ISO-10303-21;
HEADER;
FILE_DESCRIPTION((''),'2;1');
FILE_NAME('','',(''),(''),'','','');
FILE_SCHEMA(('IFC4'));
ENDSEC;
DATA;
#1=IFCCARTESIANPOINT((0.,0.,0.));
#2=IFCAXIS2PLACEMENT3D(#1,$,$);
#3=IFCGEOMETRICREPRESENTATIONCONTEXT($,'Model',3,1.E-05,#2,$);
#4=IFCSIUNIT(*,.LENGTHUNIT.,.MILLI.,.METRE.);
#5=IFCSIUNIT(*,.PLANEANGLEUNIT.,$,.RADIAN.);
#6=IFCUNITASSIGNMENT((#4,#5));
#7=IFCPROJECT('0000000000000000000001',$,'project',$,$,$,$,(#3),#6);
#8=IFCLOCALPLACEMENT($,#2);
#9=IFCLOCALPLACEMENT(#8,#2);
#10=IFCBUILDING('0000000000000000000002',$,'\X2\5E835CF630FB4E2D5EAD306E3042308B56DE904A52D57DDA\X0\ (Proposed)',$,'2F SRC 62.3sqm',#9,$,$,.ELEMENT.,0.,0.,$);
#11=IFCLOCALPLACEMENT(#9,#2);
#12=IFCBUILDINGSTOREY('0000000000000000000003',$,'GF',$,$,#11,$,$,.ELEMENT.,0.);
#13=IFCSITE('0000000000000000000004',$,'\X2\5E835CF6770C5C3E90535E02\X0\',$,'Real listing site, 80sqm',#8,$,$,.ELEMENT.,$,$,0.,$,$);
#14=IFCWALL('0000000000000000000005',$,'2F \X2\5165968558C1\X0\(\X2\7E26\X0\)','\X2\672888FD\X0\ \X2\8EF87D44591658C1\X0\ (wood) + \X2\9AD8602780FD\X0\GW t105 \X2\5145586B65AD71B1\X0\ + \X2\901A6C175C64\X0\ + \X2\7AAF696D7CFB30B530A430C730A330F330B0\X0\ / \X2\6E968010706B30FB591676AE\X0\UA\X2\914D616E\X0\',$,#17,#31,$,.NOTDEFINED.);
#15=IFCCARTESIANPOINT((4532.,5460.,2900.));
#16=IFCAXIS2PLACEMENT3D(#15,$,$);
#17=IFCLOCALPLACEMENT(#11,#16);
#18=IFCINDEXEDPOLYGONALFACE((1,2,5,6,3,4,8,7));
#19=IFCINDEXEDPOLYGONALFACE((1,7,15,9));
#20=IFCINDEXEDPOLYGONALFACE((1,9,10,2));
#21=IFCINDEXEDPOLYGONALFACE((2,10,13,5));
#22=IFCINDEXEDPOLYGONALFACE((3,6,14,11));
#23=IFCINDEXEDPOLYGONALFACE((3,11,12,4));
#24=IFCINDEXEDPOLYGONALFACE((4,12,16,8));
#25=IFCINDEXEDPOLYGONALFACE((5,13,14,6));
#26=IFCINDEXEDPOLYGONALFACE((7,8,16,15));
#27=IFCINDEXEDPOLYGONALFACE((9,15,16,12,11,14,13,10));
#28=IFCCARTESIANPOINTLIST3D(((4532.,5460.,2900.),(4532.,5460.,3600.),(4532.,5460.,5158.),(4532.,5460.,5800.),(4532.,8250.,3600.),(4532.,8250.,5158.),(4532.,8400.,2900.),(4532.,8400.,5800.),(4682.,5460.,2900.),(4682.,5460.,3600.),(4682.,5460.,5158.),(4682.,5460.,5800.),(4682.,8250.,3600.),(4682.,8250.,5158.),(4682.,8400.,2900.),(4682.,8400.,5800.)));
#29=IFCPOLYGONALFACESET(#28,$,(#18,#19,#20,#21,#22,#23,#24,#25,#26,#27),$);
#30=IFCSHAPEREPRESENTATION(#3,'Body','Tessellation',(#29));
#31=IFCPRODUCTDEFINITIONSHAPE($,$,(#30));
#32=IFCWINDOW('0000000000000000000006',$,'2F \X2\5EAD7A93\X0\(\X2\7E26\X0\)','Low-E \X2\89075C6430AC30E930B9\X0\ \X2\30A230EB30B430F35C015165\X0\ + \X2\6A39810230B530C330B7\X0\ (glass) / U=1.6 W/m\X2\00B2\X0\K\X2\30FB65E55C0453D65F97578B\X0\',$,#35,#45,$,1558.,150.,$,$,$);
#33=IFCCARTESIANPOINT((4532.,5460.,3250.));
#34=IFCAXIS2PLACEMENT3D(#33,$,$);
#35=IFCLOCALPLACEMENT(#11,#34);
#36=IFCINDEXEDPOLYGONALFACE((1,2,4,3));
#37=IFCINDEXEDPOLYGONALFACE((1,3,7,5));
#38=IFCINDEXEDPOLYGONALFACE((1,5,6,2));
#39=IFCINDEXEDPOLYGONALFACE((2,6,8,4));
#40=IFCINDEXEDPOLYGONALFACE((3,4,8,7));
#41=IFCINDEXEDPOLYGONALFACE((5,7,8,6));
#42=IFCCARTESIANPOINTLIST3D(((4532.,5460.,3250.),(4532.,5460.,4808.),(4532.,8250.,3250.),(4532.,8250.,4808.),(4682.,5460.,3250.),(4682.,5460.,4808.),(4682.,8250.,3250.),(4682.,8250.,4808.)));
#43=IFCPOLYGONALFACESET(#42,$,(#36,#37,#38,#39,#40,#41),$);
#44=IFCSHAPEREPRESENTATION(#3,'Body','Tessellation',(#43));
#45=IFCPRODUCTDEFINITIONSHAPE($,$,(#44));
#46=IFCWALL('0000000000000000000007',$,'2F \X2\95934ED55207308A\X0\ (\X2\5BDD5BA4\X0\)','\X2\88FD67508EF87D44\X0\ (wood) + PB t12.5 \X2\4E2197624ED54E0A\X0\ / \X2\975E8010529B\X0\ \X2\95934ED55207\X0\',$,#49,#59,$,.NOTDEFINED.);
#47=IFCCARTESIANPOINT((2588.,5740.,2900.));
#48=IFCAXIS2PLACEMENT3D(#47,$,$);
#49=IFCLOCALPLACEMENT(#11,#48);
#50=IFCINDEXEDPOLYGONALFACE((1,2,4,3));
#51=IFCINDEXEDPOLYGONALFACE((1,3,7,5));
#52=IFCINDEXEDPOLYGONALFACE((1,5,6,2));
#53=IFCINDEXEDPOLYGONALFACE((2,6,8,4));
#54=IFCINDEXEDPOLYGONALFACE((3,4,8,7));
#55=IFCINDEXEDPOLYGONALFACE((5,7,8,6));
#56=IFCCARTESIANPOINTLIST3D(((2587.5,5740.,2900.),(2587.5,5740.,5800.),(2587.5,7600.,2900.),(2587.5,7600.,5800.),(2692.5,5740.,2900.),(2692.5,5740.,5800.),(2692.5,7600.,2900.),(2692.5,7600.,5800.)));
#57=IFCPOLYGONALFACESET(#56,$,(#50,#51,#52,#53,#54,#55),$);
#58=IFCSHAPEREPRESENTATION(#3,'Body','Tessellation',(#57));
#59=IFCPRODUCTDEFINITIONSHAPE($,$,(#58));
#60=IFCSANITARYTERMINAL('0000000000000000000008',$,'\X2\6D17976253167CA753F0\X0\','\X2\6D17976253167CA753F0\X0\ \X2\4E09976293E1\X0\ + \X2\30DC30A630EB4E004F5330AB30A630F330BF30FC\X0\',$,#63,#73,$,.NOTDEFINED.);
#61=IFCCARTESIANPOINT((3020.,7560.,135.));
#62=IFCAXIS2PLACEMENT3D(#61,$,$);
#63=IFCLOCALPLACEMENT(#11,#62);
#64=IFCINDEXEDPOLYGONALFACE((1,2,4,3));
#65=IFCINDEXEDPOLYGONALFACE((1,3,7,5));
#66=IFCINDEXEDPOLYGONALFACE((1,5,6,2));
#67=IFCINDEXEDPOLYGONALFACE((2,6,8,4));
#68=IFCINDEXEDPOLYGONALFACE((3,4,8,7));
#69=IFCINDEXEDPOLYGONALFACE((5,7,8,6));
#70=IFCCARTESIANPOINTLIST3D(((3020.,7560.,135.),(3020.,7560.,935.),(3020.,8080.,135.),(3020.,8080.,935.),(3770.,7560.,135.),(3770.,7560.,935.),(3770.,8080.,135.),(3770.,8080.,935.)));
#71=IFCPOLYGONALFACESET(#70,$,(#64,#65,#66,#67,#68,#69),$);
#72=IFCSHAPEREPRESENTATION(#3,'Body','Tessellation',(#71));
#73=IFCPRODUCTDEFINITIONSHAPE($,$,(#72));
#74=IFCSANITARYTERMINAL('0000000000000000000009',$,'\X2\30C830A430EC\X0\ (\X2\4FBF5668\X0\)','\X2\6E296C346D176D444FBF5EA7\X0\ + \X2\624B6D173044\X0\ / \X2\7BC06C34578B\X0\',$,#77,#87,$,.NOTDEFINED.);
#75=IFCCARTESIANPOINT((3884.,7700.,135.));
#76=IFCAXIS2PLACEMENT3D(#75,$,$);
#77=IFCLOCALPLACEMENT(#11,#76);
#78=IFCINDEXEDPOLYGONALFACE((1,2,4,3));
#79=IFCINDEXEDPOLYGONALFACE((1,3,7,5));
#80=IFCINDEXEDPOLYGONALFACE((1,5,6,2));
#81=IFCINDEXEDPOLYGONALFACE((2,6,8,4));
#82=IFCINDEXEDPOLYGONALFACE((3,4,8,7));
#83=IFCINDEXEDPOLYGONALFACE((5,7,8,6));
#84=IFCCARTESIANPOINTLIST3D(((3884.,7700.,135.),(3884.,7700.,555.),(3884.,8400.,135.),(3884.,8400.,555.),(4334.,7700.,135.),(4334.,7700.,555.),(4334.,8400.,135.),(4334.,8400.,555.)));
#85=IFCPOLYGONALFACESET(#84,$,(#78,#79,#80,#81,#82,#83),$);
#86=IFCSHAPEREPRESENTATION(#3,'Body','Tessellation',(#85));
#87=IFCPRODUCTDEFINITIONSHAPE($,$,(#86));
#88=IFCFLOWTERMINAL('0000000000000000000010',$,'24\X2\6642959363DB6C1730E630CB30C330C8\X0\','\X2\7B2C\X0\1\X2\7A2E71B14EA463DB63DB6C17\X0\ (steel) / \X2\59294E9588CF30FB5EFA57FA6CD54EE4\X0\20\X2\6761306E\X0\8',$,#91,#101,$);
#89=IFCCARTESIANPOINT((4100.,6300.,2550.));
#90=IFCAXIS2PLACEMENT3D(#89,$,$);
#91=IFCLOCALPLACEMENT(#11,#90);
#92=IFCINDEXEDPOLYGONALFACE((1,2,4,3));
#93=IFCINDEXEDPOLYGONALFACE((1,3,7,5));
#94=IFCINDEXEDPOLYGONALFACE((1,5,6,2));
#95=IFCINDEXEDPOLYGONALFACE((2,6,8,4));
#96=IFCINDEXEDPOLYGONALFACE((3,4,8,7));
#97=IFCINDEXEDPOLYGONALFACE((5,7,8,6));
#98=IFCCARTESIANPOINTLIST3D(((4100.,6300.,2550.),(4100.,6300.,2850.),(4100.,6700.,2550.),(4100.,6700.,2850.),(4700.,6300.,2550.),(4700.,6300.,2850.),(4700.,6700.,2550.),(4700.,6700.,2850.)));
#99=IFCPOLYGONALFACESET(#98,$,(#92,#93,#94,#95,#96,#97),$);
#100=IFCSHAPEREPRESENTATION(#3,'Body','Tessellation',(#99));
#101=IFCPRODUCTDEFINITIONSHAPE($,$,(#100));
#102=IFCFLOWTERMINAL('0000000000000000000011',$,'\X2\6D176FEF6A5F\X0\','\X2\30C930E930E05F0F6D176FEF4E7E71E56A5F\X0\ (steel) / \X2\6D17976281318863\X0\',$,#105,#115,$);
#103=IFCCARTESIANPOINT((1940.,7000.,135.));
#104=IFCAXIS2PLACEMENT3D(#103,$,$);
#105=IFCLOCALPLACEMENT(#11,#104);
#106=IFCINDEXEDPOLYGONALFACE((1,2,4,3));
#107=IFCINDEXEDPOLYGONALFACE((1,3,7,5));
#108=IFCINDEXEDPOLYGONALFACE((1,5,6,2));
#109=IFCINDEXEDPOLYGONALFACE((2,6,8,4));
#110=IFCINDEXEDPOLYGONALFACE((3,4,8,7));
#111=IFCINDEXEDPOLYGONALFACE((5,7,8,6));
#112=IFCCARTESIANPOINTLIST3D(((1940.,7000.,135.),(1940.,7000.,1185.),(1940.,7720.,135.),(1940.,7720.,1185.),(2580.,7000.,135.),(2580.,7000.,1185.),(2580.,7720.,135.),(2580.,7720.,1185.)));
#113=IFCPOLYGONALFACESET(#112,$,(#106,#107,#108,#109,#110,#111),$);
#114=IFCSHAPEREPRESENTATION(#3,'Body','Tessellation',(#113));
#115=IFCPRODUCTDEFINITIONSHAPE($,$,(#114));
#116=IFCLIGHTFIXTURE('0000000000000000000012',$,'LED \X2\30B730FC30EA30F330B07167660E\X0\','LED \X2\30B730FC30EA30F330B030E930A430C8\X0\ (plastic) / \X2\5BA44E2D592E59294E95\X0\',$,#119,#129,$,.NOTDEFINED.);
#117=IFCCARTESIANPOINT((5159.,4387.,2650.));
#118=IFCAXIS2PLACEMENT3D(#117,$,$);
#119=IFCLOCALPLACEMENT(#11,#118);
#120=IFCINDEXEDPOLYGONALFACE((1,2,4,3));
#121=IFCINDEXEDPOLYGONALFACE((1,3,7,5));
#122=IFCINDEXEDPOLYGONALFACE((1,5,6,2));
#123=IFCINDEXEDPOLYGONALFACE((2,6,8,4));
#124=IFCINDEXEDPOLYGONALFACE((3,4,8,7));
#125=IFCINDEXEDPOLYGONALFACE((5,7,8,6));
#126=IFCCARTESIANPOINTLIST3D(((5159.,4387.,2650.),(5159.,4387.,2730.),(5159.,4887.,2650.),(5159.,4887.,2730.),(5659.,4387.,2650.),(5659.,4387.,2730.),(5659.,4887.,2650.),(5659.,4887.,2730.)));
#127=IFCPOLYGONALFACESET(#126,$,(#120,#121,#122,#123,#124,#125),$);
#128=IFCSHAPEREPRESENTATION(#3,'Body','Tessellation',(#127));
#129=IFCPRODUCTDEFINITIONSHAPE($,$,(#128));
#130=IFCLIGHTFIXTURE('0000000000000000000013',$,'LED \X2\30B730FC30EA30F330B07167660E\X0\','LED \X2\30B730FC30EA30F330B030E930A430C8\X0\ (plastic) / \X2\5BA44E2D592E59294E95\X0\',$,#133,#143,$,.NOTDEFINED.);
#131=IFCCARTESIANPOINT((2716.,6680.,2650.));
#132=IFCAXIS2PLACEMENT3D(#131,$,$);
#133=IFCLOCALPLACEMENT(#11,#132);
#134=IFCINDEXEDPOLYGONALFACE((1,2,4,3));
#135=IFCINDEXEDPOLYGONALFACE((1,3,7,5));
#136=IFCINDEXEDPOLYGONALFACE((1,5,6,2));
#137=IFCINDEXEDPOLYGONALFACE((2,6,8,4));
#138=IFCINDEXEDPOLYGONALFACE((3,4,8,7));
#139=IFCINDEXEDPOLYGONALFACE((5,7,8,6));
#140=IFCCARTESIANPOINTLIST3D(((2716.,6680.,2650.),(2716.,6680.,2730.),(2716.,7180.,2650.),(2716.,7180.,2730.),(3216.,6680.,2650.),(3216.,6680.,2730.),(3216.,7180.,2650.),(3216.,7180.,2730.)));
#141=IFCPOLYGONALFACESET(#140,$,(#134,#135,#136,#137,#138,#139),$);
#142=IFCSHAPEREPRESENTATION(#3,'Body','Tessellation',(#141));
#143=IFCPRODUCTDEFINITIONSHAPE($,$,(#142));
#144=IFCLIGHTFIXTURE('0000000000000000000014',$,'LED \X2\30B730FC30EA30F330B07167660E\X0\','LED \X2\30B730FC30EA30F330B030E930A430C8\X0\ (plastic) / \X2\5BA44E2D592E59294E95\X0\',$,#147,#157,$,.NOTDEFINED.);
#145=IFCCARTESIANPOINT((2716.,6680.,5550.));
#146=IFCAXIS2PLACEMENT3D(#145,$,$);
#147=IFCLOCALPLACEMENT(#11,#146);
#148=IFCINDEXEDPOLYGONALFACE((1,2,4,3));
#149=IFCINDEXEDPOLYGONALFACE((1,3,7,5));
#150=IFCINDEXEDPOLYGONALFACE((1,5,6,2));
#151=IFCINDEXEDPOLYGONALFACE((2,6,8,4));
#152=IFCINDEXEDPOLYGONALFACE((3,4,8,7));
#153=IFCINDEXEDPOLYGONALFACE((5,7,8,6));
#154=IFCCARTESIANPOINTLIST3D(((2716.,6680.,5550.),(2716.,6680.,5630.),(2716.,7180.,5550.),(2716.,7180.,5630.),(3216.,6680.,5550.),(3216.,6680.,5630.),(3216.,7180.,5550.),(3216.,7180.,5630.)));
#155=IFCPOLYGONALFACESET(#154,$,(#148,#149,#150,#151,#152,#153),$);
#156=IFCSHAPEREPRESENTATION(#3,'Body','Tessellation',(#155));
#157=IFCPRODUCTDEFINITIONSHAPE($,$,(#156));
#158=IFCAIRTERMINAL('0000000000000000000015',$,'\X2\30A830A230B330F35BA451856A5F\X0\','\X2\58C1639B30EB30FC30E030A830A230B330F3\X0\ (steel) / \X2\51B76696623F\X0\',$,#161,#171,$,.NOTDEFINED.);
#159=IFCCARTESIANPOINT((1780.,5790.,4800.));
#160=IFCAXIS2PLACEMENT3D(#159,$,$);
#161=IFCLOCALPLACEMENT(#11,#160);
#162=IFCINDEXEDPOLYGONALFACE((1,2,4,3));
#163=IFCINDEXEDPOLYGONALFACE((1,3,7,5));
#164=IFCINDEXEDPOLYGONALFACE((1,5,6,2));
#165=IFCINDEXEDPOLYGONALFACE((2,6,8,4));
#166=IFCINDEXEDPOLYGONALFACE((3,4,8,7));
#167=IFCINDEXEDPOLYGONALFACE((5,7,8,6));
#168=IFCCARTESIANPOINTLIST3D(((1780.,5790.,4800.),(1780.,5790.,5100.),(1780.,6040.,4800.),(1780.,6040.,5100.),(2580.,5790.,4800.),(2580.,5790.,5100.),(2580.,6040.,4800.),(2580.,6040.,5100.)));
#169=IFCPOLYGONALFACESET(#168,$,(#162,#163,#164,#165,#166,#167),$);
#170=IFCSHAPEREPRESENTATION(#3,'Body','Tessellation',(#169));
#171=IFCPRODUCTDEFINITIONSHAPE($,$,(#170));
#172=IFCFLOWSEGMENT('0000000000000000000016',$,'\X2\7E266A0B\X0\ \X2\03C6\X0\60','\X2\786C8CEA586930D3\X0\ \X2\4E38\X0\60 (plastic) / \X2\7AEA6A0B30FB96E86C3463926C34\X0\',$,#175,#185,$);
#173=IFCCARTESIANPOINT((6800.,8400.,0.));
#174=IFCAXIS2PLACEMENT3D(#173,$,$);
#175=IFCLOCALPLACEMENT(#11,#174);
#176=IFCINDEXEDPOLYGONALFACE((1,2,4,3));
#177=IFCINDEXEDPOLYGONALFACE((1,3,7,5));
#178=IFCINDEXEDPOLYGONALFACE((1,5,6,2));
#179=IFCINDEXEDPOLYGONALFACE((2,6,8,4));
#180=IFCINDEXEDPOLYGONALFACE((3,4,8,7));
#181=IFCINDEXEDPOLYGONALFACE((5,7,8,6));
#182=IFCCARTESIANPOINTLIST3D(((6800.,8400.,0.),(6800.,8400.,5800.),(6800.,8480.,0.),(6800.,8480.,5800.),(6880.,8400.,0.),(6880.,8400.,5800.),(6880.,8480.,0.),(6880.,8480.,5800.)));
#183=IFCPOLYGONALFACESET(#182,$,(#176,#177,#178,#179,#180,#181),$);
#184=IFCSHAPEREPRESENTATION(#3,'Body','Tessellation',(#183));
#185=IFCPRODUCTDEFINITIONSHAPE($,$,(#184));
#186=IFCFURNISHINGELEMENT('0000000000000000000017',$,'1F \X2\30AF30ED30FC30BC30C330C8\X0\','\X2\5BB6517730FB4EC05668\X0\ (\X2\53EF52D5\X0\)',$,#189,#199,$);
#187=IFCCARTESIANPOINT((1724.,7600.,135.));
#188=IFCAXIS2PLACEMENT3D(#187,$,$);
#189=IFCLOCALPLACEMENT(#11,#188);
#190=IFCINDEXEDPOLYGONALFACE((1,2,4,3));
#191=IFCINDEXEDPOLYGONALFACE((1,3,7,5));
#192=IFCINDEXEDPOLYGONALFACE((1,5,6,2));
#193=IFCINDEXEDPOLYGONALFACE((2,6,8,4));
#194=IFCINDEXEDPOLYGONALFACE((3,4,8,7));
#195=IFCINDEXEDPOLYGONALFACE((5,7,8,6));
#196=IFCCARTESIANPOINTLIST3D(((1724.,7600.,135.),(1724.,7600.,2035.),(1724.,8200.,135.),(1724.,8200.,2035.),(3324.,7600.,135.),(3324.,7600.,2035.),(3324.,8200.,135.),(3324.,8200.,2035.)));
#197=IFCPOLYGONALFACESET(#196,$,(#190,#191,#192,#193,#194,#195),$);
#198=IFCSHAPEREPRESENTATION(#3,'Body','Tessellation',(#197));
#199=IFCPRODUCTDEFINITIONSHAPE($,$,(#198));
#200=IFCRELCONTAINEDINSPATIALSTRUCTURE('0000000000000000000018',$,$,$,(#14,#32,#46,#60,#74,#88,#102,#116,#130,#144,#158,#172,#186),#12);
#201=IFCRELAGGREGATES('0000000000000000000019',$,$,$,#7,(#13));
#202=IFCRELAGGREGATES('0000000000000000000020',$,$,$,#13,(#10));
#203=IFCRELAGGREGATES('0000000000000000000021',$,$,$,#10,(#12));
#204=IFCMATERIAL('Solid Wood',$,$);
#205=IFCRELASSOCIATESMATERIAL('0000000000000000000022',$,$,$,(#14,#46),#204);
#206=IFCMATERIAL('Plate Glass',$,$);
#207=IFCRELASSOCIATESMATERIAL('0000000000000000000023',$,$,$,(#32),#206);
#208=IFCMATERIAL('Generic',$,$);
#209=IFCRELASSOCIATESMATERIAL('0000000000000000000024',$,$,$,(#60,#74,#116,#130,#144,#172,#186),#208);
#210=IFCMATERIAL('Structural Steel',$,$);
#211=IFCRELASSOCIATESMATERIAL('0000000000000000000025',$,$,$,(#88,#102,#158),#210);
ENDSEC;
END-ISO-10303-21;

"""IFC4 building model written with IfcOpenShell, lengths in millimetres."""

from ifc_helpers import new_model, si_unit, frame, frame_2d, origin, place, context, project, spatial, rectangle, extrude, material, element, fill, save


model = new_model("IFC4")

# Units and contexts
model_context = context("Model", 3, precision=1e-05, world=origin())
ifc_project = project(units=[si_unit("LENGTHUNIT", "METRE", prefix="MILLI"), si_unit("PLANEANGLEUNIT", "RADIAN")], contexts=[model_context])

# Site, building, storey
site_placement = place(None, origin())
site = spatial("IfcSite", under=ifc_project, at=site_placement, Name="広島県尾道市", ObjectType="Real listing site, 80sqm", CompositionType="ELEMENT", RefElevation=0.0)
building_placement = place(site_placement, origin())
building = spatial("IfcBuilding", under=site, at=building_placement, Name="広島・中庭のある回遊動線 (Proposed)", ObjectType="2F SRC 62.3sqm", CompositionType="ELEMENT", ElevationOfRefHeight=0.0, ElevationOfTerrain=0.0)
storey_placement = place(building_placement, origin())
storey = spatial("IfcBuildingStorey", under=building, at=storey_placement, Name="GF", CompositionType="ELEMENT", Elevation=0.0)

# Shared definitions
ifc_material_1 = material(Name="Solid Wood")

# Shared definitions
ifc_material_2 = material(Name="Plate Glass")

# Wall, opening, window
wall_1_placement = place(storey_placement, frame((4532.0, 5460.0, 2900.0)))
wall_1 = element("IfcWall", 1, at=wall_1_placement, inside=storey, material=ifc_material_1, Name="2F 入隅壁(縦)", Description="木製 軸組外壁 (wood) + 高性能GW t105 充填断熱 + 通気層 + 窯業系サイディング / 準耐火・外皮UA配慮", PredefinedType="NOTDEFINED", context=model_context, shape_type="SweptSolid", body=[
    extrude(rectangle(XDim=150.0, YDim=2940.0, at=frame_2d((75.0, 1470.0))), frame((4532.0, 5460.0, 2900.0)), (0.0, 0.0, 1.0), 2900.0),
])
opening_1_placement = place(storey_placement, frame((4532.0, 5460.0, 3250.0)))
opening_1 = element("IfcOpeningElement", 2, at=opening_1_placement, cuts=wall_1, PredefinedType="NOTDEFINED", context=model_context, shape_type="SweptSolid", body=[
    extrude(rectangle(XDim=150.0, YDim=2790.0, at=frame_2d((75.0, 1395.0))), frame((4532.0, 5460.0, 3250.0)), (0.0, 0.0, 1.0), 1558.0),
])
window_1_placement = place(storey_placement, frame((4532.0, 5460.0, 3250.0)))
window_1 = element("IfcWindow", 3, at=window_1_placement, inside=storey, material=ifc_material_2, Name="2F 庭窓(縦)", Description="Low-E 複層ガラス アルゴン封入 + 樹脂サッシ (glass) / U=1.6 W/m²K・日射取得型", OverallHeight=1558.0, OverallWidth=150.0, context=model_context, shape_type="SweptSolid", body=[
    extrude(rectangle(XDim=150.0, YDim=2790.0, at=frame_2d((75.0, 1395.0))), frame((4532.0, 5460.0, 3250.0)), (0.0, 0.0, 1.0), 1558.0),
])
fill(opening_1, window_1)

# Wall
wall_2_placement = place(storey_placement, frame((2588.0, 5740.0, 2900.0)))
element("IfcWall", 4, at=wall_2_placement, inside=storey, material=ifc_material_1, Name="2F 間仕切り (寝室)", Description="製材軸組 (wood) + PB t12.5 両面仕上 / 非耐力 間仕切", PredefinedType="NOTDEFINED", context=model_context, shape_type="SweptSolid", body=[
    extrude(rectangle(XDim=105.0, YDim=1860.0, at=frame_2d((52.0, 930.0))), frame((2588.0, 5740.0, 2900.0)), (0.0, 0.0, 1.0), 2900.0),
])

# Sanitary terminals
ifc_material_3 = material(Name="Generic")
sanitary_terminal_1_placement = place(storey_placement, frame((3020.0, 7560.0, 135.0)))
element("IfcSanitaryTerminal", 5, at=sanitary_terminal_1_placement, inside=storey, material=ifc_material_3, Name="洗面化粧台", Description="洗面化粧台 三面鏡 + ボウル一体カウンター", PredefinedType="NOTDEFINED", context=model_context, shape_type="SweptSolid", body=[
    extrude(rectangle(XDim=750.0, YDim=520.0, at=frame_2d((375.0, 260.0))), frame((3020.0, 7560.0, 135.0)), (0.0, 0.0, 1.0), 800.0),
])
sanitary_terminal_2_placement = place(storey_placement, frame((3884.0, 7700.0, 135.0)))
element("IfcSanitaryTerminal", 6, at=sanitary_terminal_2_placement, inside=storey, material=ifc_material_3, Name="トイレ (便器)", Description="温水洗浄便座 + 手洗い / 節水型", PredefinedType="NOTDEFINED", context=model_context, shape_type="SweptSolid", body=[
    extrude(rectangle(XDim=450.0, YDim=700.0, at=frame_2d((225.0, 350.0))), frame((3884.0, 7700.0, 135.0)), (0.0, 0.0, 1.0), 420.0),
])

# Flow terminals
ifc_material_4 = material(Name="Structural Steel")
flow_terminal_1_placement = place(storey_placement, frame((4100.0, 6300.0, 2550.0)))
element("IfcFlowTerminal", 7, at=flow_terminal_1_placement, inside=storey, material=ifc_material_4, Name="24時間換気ユニット", Description="第1種熱交換換気 (steel) / 天井裏・建基法令20条の8", context=model_context, shape_type="SweptSolid", body=[
    extrude(rectangle(XDim=600.0, YDim=400.0, at=frame_2d((300.0, 200.0))), frame((4100.0, 6300.0, 2550.0)), (0.0, 0.0, 1.0), 300.0),
])
flow_terminal_2_placement = place(storey_placement, frame((1940.0, 7000.0, 135.0)))
element("IfcFlowTerminal", 8, at=flow_terminal_2_placement, inside=storey, material=ifc_material_4, Name="洗濯機", Description="ドラム式洗濯乾燥機 (steel) / 洗面脱衣", context=model_context, shape_type="SweptSolid", body=[
    extrude(rectangle(XDim=640.0, YDim=720.0, at=frame_2d((320.0, 360.0))), frame((1940.0, 7000.0, 135.0)), (0.0, 0.0, 1.0), 1050.0),
])

# Light fixtures
light_fixture_1_placement = place(storey_placement, frame((5159.0, 4387.0, 2650.0)))
element("IfcLightFixture", 9, at=light_fixture_1_placement, inside=storey, material=ifc_material_3, Name="LED シーリング照明", Description="LED シーリングライト (plastic) / 室中央天井", PredefinedType="NOTDEFINED", context=model_context, shape_type="SweptSolid", body=[
    extrude(rectangle(XDim=500.0, YDim=500.0, at=frame_2d((250.0, 250.0))), frame((5159.0, 4387.0, 2650.0)), (0.0, 0.0, 1.0), 80.0),
])
light_fixture_2_placement = place(storey_placement, frame((2716.0, 6680.0, 2650.0)))
element("IfcLightFixture", 10, at=light_fixture_2_placement, inside=storey, material=ifc_material_3, Name="LED シーリング照明", Description="LED シーリングライト (plastic) / 室中央天井", PredefinedType="NOTDEFINED", context=model_context, shape_type="SweptSolid", body=[
    extrude(rectangle(XDim=500.0, YDim=500.0, at=frame_2d((250.0, 250.0))), frame((2716.0, 6680.0, 2650.0)), (0.0, 0.0, 1.0), 80.0),
])
light_fixture_3_placement = place(storey_placement, frame((2716.0, 6680.0, 5550.0)))
element("IfcLightFixture", 11, at=light_fixture_3_placement, inside=storey, material=ifc_material_3, Name="LED シーリング照明", Description="LED シーリングライト (plastic) / 室中央天井", PredefinedType="NOTDEFINED", context=model_context, shape_type="SweptSolid", body=[
    extrude(rectangle(XDim=500.0, YDim=500.0, at=frame_2d((250.0, 250.0))), frame((2716.0, 6680.0, 5550.0)), (0.0, 0.0, 1.0), 80.0),
])

# Air terminal
air_terminal_placement = place(storey_placement, frame((1780.0, 5790.0, 4800.0)))
element("IfcAirTerminal", 12, at=air_terminal_placement, inside=storey, material=ifc_material_4, Name="エアコン室内機", Description="壁掛ルームエアコン (steel) / 冷暖房", PredefinedType="NOTDEFINED", context=model_context, shape_type="SweptSolid", body=[
    extrude(rectangle(XDim=800.0, YDim=250.0, at=frame_2d((400.0, 125.0))), frame((1780.0, 5790.0, 4800.0)), (0.0, 0.0, 1.0), 300.0),
])

# Flow segment
flow_segment_placement = place(storey_placement, frame((6800.0, 8400.0, 0.0)))
element("IfcFlowSegment", 13, at=flow_segment_placement, inside=storey, material=ifc_material_3, Name="縦樋 φ60", Description="硬質塩ビ 丸60 (plastic) / 竪樋・雨水排水", context=model_context, shape_type="SweptSolid", body=[
    extrude(rectangle(XDim=80.0, YDim=80.0, at=frame_2d((40.0, 40.0))), frame((6800.0, 8400.0, 0.0)), (0.0, 0.0, 1.0), 5800.0),
])

# Furnishing element
furnishing_1_placement = place(storey_placement, frame((1724.0, 7600.0, 135.0)))
element("IfcFurnishingElement", 14, at=furnishing_1_placement, inside=storey, material=ifc_material_3, Name="1F クローゼット", Description="家具・什器 (可動)", context=model_context, shape_type="SweptSolid", body=[
    extrude(rectangle(XDim=1600.0, YDim=600.0, at=frame_2d((800.0, 300.0))), frame((1724.0, 7600.0, 135.0)), (0.0, 0.0, 1.0), 1900.0),
])

save(model, "model.ifc")
